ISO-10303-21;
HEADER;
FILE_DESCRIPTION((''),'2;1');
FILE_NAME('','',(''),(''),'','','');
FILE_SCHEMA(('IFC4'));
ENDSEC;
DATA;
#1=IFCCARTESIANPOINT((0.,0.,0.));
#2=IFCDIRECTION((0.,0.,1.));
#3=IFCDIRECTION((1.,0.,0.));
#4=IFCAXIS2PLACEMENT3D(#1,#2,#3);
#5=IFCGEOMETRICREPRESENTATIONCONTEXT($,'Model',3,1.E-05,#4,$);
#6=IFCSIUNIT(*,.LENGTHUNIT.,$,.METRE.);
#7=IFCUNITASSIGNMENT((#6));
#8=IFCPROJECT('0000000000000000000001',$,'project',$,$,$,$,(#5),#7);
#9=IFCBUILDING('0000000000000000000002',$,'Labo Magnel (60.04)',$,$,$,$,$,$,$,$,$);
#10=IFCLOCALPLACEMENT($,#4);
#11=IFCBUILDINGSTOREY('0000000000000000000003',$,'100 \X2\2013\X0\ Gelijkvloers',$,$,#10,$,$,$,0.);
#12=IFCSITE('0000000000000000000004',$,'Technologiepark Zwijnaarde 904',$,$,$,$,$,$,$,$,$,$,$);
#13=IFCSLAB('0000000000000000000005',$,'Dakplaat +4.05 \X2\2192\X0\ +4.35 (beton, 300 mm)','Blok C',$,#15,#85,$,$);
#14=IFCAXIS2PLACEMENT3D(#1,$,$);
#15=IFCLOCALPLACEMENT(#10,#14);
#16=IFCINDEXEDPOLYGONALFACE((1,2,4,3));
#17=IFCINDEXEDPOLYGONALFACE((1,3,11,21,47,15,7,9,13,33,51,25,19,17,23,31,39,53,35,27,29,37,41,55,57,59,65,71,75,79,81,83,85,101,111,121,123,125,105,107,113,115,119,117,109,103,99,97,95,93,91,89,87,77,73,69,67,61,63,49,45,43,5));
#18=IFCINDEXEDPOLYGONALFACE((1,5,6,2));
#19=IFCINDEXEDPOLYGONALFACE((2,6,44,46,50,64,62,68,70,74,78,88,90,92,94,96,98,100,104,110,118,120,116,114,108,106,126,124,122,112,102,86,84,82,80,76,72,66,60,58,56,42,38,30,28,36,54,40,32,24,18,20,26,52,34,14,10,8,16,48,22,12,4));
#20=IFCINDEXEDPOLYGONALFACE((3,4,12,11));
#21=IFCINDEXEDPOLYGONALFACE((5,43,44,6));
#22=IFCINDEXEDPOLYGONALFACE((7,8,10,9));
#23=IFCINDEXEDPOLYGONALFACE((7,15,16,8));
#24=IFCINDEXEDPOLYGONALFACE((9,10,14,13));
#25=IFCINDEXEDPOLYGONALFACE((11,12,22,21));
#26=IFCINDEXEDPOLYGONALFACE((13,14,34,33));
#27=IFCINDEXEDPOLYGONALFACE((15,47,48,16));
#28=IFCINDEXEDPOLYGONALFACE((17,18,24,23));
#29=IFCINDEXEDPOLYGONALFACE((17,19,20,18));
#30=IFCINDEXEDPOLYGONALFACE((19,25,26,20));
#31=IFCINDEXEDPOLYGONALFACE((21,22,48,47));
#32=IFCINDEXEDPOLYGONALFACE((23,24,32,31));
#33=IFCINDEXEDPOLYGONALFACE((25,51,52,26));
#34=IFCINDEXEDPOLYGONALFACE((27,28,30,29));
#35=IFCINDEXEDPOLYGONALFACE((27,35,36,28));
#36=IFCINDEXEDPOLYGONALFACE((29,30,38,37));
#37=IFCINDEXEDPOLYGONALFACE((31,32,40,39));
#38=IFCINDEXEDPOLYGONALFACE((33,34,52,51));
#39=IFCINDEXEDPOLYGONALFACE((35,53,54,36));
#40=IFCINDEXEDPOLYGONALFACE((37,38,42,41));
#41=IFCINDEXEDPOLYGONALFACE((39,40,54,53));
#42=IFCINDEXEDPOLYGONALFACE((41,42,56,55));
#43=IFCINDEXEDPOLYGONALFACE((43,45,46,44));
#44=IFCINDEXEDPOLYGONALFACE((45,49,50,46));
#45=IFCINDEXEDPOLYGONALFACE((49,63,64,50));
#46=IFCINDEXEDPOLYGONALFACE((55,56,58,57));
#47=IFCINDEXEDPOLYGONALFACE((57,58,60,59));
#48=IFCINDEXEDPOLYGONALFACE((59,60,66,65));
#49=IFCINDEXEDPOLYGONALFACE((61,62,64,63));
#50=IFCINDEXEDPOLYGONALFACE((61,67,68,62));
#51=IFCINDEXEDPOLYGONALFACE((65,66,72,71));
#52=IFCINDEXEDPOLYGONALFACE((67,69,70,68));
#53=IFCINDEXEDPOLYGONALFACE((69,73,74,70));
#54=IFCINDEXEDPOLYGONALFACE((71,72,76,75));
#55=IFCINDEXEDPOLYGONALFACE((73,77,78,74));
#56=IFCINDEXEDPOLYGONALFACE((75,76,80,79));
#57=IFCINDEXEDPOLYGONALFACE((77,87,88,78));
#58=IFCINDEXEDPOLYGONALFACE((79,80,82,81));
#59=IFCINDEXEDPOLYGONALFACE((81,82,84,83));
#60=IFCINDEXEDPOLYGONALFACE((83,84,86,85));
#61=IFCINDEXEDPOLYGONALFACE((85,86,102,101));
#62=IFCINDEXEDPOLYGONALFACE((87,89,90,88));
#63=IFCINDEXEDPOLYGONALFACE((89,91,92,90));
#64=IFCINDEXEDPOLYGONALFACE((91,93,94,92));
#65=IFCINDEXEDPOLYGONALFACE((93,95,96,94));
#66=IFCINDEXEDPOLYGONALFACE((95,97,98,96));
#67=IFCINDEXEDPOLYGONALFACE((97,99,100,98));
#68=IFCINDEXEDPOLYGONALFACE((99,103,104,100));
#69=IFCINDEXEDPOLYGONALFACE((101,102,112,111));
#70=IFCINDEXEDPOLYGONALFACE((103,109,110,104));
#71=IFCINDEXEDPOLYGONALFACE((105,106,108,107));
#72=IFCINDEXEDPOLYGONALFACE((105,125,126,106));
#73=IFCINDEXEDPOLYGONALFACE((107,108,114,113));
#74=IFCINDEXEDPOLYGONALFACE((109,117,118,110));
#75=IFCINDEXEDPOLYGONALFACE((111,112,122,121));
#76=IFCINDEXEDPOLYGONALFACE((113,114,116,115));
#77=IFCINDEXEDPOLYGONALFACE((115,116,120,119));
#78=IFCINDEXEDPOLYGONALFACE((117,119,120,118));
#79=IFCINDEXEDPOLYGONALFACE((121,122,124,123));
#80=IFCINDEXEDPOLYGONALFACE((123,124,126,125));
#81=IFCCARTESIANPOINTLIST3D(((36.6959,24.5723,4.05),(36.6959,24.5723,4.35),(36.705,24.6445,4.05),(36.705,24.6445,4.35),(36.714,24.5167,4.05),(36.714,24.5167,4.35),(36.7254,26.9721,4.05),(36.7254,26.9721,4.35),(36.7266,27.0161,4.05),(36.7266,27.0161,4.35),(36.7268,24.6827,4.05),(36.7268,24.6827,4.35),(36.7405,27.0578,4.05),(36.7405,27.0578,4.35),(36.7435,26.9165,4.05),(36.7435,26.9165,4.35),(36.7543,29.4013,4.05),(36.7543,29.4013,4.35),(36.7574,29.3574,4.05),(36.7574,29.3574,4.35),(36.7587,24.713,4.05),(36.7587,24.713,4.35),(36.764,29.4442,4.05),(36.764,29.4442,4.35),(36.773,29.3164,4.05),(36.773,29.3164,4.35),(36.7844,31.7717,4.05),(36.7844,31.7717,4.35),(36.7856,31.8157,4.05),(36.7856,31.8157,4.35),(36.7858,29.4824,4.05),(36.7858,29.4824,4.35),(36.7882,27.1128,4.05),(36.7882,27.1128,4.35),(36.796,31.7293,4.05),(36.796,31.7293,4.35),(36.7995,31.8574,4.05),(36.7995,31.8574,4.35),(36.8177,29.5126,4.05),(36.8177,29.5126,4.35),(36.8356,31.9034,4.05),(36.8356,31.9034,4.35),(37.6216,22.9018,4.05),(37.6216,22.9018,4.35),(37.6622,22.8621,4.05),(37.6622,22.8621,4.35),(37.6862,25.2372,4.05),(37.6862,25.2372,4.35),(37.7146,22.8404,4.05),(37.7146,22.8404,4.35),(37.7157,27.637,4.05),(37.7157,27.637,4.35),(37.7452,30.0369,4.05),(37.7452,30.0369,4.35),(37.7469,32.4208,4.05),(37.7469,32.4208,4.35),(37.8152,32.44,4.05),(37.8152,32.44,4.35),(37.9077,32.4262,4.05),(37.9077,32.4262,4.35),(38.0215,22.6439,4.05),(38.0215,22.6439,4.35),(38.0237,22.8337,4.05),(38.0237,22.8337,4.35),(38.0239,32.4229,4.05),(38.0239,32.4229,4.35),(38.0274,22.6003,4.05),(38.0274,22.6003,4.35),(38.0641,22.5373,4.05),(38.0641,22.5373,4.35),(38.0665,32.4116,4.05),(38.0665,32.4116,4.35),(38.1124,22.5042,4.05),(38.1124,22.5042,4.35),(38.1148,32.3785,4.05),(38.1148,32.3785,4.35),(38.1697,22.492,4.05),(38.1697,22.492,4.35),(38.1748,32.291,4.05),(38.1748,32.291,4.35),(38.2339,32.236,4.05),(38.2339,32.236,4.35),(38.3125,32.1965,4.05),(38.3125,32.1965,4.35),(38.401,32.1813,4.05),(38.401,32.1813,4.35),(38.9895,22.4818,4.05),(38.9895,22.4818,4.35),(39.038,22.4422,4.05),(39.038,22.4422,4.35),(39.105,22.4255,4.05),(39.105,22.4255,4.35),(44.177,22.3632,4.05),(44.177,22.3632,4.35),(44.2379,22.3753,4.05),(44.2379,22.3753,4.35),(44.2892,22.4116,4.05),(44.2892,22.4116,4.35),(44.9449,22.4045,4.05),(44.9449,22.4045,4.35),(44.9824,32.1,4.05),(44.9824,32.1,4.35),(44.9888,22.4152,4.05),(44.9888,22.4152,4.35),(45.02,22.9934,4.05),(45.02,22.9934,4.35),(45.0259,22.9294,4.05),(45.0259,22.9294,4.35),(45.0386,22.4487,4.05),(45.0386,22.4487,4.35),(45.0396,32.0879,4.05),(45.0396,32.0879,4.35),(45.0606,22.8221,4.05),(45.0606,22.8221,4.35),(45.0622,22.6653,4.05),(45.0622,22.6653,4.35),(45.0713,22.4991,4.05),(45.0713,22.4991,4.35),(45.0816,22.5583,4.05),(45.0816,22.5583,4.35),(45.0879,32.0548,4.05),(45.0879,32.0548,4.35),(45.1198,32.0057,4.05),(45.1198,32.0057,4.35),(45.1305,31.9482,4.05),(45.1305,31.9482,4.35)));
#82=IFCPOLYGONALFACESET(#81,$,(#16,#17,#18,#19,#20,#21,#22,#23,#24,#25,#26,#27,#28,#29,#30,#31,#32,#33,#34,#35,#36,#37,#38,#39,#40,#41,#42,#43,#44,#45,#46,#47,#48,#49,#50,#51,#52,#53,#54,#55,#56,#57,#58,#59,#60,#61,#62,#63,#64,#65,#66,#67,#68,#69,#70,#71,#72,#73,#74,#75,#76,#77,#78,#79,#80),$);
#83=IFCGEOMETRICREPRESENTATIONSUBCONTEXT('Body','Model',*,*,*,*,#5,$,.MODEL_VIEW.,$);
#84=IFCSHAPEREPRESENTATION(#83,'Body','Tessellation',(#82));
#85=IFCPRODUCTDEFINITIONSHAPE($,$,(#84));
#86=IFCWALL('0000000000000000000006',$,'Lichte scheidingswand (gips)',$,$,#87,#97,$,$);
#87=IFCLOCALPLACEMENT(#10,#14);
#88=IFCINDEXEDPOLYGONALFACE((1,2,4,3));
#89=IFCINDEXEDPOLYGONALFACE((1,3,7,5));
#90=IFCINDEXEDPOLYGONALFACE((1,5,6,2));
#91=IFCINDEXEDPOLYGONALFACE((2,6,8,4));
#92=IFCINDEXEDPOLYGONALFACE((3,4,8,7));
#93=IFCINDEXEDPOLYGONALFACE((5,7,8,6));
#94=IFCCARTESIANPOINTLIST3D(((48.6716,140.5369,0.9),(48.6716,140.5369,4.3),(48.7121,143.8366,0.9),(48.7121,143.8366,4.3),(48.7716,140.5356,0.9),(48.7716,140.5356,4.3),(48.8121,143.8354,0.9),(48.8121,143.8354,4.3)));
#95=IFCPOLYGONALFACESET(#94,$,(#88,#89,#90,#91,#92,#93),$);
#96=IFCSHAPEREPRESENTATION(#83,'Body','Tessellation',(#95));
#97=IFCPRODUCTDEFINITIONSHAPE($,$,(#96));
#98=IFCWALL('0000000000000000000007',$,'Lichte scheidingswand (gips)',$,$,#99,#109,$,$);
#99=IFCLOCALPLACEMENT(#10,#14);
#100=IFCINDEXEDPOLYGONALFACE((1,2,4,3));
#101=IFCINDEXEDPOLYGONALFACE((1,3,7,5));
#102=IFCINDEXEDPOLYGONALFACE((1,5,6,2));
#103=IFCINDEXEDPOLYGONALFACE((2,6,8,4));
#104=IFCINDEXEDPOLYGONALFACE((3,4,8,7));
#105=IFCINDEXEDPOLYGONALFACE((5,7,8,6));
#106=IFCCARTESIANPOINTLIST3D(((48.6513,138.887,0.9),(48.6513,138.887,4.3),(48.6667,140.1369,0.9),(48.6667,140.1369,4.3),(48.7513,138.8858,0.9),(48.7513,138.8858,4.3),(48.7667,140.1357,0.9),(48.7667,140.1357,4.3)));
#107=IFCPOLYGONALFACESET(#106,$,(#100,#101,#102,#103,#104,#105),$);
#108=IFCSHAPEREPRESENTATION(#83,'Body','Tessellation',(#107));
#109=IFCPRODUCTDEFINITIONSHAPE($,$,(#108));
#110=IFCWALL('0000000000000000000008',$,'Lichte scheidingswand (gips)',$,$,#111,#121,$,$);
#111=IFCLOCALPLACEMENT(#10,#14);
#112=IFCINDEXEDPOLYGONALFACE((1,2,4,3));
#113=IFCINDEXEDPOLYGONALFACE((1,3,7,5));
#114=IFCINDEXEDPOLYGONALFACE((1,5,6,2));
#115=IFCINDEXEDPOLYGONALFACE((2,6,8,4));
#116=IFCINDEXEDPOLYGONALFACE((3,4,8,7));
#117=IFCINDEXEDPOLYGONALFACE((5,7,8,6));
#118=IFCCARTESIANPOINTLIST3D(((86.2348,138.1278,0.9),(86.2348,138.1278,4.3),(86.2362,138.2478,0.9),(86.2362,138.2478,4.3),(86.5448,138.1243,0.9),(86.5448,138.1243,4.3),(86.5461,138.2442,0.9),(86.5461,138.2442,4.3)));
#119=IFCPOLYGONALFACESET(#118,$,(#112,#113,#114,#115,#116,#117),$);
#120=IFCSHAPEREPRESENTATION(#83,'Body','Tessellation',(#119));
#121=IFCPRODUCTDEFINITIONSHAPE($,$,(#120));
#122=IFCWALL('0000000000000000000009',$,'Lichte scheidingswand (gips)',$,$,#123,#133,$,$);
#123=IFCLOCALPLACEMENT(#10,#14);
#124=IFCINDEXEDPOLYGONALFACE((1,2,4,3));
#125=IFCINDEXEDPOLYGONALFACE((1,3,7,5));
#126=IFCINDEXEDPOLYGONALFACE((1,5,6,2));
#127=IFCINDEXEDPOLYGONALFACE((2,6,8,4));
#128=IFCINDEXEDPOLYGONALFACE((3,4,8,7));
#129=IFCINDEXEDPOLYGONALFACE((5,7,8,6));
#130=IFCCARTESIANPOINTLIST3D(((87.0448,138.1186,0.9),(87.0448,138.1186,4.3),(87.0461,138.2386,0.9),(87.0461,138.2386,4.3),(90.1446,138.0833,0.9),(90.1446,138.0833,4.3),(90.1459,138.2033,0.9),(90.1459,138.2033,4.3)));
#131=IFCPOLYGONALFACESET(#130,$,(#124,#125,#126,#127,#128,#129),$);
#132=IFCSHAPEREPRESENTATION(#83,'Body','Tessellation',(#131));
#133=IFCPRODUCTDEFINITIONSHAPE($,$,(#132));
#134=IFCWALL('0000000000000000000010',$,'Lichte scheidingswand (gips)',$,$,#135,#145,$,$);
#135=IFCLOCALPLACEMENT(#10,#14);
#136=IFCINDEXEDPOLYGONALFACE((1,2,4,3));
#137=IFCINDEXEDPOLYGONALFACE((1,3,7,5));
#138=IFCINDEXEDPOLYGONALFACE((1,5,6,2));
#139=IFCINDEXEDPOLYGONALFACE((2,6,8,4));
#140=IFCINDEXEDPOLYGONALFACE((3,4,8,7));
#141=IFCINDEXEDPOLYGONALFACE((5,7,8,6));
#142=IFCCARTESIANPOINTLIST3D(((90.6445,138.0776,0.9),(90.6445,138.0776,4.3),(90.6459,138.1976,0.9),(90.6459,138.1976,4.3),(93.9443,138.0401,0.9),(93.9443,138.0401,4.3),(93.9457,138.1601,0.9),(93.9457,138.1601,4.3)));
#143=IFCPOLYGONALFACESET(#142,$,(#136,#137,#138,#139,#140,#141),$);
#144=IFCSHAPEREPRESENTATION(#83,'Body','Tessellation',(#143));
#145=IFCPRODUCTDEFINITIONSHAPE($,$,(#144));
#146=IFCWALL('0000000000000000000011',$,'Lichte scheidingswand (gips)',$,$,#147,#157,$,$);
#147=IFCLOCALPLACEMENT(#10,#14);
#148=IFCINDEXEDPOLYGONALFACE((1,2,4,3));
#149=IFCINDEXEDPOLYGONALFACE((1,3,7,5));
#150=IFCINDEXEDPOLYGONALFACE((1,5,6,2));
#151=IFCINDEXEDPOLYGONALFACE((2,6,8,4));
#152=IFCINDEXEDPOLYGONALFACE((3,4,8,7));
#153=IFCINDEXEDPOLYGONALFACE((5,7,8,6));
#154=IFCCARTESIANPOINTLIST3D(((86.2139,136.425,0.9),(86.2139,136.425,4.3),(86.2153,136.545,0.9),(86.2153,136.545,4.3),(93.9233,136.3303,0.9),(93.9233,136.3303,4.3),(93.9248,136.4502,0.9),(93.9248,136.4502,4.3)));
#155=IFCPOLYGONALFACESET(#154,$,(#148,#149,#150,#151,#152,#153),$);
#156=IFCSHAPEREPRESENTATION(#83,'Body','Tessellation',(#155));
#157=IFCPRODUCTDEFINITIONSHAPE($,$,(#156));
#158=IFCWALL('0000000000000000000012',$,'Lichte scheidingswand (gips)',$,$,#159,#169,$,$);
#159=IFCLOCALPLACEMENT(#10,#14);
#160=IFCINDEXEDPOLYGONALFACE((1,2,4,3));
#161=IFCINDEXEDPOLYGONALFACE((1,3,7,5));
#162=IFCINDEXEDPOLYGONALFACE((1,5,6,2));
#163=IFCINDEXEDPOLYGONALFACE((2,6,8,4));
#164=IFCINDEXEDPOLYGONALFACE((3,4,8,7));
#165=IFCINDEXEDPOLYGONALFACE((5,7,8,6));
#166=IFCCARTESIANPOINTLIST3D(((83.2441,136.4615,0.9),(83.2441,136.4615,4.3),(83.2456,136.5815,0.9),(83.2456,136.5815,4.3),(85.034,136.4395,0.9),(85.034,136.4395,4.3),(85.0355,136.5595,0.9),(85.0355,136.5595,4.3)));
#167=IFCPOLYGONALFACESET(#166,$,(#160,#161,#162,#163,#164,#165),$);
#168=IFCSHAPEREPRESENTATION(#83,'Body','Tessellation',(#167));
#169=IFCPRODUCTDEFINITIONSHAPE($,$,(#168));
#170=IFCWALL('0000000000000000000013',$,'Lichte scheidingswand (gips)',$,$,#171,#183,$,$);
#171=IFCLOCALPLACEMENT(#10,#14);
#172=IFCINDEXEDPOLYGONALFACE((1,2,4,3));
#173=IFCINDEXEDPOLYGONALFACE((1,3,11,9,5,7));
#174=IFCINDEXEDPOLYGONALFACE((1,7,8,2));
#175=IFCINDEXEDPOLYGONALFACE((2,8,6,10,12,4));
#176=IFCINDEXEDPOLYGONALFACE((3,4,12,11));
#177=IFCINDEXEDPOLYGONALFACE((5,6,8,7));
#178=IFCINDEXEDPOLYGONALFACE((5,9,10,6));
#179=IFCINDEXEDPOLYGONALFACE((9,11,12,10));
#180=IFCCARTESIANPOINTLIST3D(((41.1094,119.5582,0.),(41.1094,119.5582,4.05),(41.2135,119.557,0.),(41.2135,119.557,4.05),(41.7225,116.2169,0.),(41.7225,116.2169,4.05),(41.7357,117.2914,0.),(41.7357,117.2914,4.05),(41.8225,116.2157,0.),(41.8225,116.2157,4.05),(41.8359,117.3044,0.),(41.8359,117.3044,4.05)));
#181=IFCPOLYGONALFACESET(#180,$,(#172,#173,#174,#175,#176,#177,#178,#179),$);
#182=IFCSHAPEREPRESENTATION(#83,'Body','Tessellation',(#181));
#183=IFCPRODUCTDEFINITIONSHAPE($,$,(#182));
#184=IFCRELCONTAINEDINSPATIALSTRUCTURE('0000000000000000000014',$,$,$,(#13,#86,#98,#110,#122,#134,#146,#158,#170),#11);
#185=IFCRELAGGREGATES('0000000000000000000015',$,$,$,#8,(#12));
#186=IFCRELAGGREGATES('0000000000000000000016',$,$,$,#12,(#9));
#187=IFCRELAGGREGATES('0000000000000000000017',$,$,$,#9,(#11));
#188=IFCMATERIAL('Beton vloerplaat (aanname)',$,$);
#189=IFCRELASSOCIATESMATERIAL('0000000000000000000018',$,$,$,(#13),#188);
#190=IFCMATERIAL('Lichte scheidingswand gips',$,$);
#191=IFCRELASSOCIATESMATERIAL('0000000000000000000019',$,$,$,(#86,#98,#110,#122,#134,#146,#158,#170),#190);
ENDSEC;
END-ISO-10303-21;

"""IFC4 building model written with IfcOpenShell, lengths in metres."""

from ifc_helpers import new_model, si_unit, frame, origin, origin_with_axes, place, context, subcontext, project, spatial, polyline, outline, extrude, material, element, save


model = new_model("IFC4")

# Units and contexts
model_context = context("Model", 3, precision=1e-05, world=origin_with_axes())
body_context = subcontext(model_context, "Body", "Model", "MODEL_VIEW")
ifc_project = project(units=[si_unit("LENGTHUNIT", "METRE")], contexts=[model_context])

# Site, building, storey
site = spatial("IfcSite", under=ifc_project, Name="Technologiepark Zwijnaarde 904")
building = spatial("IfcBuilding", under=site, Name="Labo Magnel (60.04)")
storey_placement = place(None, origin_with_axes())
storey = spatial("IfcBuildingStorey", under=building, at=storey_placement, Name="100 – Gelijkvloers", Elevation=0.0)

# Slab
ifc_material_1 = material(Name="Beton vloerplaat (aanname)")
slab_1_placement = place(storey_placement, frame((0.0, 0.0, 4.05), z_axis=(0.0, 0.0, 1.0), x_axis=(1.0, 0.0, 0.0)))
element("IfcSlab", 1, at=slab_1_placement, inside=storey, material=ifc_material_1, Name="Dakplaat +4.05 → +4.35 (beton, 300 mm)", Description="Blok C", context=body_context, shape_type="SweptSolid", body=[
    extrude(outline(polyline([(37.6862, 25.2372), (36.7435, 26.9165), (36.7254, 26.9721), (36.7266, 27.0161), (36.7405, 27.0578), (36.7882, 27.1128), (37.7157, 27.637), (36.773, 29.3164), (36.7574, 29.3574), (36.7543, 29.4013), (36.764, 29.4442), (36.7858, 29.4824), (36.8177, 29.5126), (37.7452, 30.0369), (36.796, 31.7293), (36.7844, 31.7717), (36.7856, 31.8157), (36.7995, 31.8574), (36.8356, 31.9034), (37.7469, 32.4208), (37.8152, 32.44), (37.9077, 32.4262), (38.0239, 32.4229), (38.0665, 32.4116), (38.1148, 32.3785), (38.1748, 32.291), (38.2339, 32.236), (38.3125, 32.1965), (38.401, 32.1813), (44.9824, 32.1), (45.0396, 32.0879), (45.0879, 32.0548), (45.1198, 32.0057), (45.1305, 31.9482), (45.02, 22.9934), (45.0259, 22.9294), (45.0606, 22.8221), (45.0622, 22.6653), (45.0816, 22.5583), (45.0713, 22.4991), (45.0386, 22.4487), (44.9888, 22.4152), (44.9449, 22.4045), (44.2892, 22.4116), (44.2379, 22.3753), (44.177, 22.3632), (39.105, 22.4255), (39.038, 22.4422), (38.9895, 22.4818), (38.1697, 22.492), (38.1124, 22.5042), (38.0641, 22.5373), (38.0274, 22.6003), (38.0215, 22.6439), (38.0237, 22.8337), (37.7146, 22.8404), (37.6622, 22.8621), (37.6216, 22.9018), (36.714, 24.5167), (36.6959, 24.5723), (36.705, 24.6445), (36.7268, 24.6827), (36.7587, 24.713), (37.6862, 25.2372)])), origin(), (0.0, 0.0, 1.0), 0.3),
])

# Walls
ifc_material_2 = material(Name="Lichte scheidingswand gips")
wall_1_placement = place(storey_placement, frame((0.0, 0.0, 0.9), z_axis=(0.0, 0.0, 1.0), x_axis=(1.0, 0.0, 0.0)))
element("IfcWall", 2, at=wall_1_placement, inside=storey, material=ifc_material_2, Name="Lichte scheidingswand (gips)", context=body_context, shape_type="SweptSolid", body=[
    extrude(outline(polyline([(48.8121, 143.8354), (48.7121, 143.8366), (48.6716, 140.5369), (48.7716, 140.5356), (48.8121, 143.8354)])), origin(), (0.0, 0.0, 1.0), 3.4),
])
wall_2_placement = place(storey_placement, frame((0.0, 0.0, 0.9), z_axis=(0.0, 0.0, 1.0), x_axis=(1.0, 0.0, 0.0)))
element("IfcWall", 3, at=wall_2_placement, inside=storey, material=ifc_material_2, Name="Lichte scheidingswand (gips)", context=body_context, shape_type="SweptSolid", body=[
    extrude(outline(polyline([(48.7667, 140.1357), (48.6667, 140.1369), (48.6513, 138.887), (48.7513, 138.8858), (48.7667, 140.1357)])), origin(), (0.0, 0.0, 1.0), 3.4),
])
wall_3_placement = place(storey_placement, frame((0.0, 0.0, 0.9), z_axis=(0.0, 0.0, 1.0), x_axis=(1.0, 0.0, 0.0)))
element("IfcWall", 4, at=wall_3_placement, inside=storey, material=ifc_material_2, Name="Lichte scheidingswand (gips)", context=body_context, shape_type="SweptSolid", body=[
    extrude(outline(polyline([(86.2362, 138.2478), (86.5461, 138.2442), (86.5448, 138.1243), (86.2348, 138.1278), (86.2362, 138.2478)])), origin(), (0.0, 0.0, 1.0), 3.4),
])
wall_4_placement = place(storey_placement, frame((0.0, 0.0, 0.9), z_axis=(0.0, 0.0, 1.0), x_axis=(1.0, 0.0, 0.0)))
element("IfcWall", 5, at=wall_4_placement, inside=storey, material=ifc_material_2, Name="Lichte scheidingswand (gips)", context=body_context, shape_type="SweptSolid", body=[
    extrude(outline(polyline([(87.0448, 138.1186), (90.1446, 138.0833), (90.1459, 138.2033), (87.0461, 138.2386), (87.0448, 138.1186)])), origin(), (0.0, 0.0, 1.0), 3.4),
])
wall_5_placement = place(storey_placement, frame((0.0, 0.0, 0.9), z_axis=(0.0, 0.0, 1.0), x_axis=(1.0, 0.0, 0.0)))
element("IfcWall", 6, at=wall_5_placement, inside=storey, material=ifc_material_2, Name="Lichte scheidingswand (gips)", context=body_context, shape_type="SweptSolid", body=[
    extrude(outline(polyline([(90.6445, 138.0776), (93.9443, 138.0401), (93.9457, 138.1601), (90.6459, 138.1976), (90.6445, 138.0776)])), origin(), (0.0, 0.0, 1.0), 3.4),
])
wall_6_placement = place(storey_placement, frame((0.0, 0.0, 0.9), z_axis=(0.0, 0.0, 1.0), x_axis=(1.0, 0.0, 0.0)))
element("IfcWall", 7, at=wall_6_placement, inside=storey, material=ifc_material_2, Name="Lichte scheidingswand (gips)", context=body_context, shape_type="SweptSolid", body=[
    extrude(outline(polyline([(86.2139, 136.425), (93.9233, 136.3303), (93.9248, 136.4502), (86.2153, 136.545), (86.2139, 136.425)])), origin(), (0.0, 0.0, 1.0), 3.4),
])
wall_7_placement = place(storey_placement, frame((0.0, 0.0, 0.9), z_axis=(0.0, 0.0, 1.0), x_axis=(1.0, 0.0, 0.0)))
element("IfcWall", 8, at=wall_7_placement, inside=storey, material=ifc_material_2, Name="Lichte scheidingswand (gips)", context=body_context, shape_type="SweptSolid", body=[
    extrude(outline(polyline([(85.034, 136.4395), (83.2441, 136.4615), (83.2456, 136.5815), (85.0355, 136.5595), (85.034, 136.4395)])), origin(), (0.0, 0.0, 1.0), 3.4),
])
wall_8_placement = place(storey_placement, origin_with_axes())
element("IfcWall", 9, at=wall_8_placement, inside=storey, material=ifc_material_2, Name="Lichte scheidingswand (gips)", context=body_context, shape_type="SweptSolid", body=[
    extrude(outline(polyline([(41.7225, 116.2169), (41.7357, 117.2914), (41.1094, 119.5582), (41.2135, 119.557), (41.8359, 117.3044), (41.8225, 116.2157), (41.7225, 116.2169)])), origin(), (0.0, 0.0, 1.0), 4.05),
])

save(model, "model.ifc")
